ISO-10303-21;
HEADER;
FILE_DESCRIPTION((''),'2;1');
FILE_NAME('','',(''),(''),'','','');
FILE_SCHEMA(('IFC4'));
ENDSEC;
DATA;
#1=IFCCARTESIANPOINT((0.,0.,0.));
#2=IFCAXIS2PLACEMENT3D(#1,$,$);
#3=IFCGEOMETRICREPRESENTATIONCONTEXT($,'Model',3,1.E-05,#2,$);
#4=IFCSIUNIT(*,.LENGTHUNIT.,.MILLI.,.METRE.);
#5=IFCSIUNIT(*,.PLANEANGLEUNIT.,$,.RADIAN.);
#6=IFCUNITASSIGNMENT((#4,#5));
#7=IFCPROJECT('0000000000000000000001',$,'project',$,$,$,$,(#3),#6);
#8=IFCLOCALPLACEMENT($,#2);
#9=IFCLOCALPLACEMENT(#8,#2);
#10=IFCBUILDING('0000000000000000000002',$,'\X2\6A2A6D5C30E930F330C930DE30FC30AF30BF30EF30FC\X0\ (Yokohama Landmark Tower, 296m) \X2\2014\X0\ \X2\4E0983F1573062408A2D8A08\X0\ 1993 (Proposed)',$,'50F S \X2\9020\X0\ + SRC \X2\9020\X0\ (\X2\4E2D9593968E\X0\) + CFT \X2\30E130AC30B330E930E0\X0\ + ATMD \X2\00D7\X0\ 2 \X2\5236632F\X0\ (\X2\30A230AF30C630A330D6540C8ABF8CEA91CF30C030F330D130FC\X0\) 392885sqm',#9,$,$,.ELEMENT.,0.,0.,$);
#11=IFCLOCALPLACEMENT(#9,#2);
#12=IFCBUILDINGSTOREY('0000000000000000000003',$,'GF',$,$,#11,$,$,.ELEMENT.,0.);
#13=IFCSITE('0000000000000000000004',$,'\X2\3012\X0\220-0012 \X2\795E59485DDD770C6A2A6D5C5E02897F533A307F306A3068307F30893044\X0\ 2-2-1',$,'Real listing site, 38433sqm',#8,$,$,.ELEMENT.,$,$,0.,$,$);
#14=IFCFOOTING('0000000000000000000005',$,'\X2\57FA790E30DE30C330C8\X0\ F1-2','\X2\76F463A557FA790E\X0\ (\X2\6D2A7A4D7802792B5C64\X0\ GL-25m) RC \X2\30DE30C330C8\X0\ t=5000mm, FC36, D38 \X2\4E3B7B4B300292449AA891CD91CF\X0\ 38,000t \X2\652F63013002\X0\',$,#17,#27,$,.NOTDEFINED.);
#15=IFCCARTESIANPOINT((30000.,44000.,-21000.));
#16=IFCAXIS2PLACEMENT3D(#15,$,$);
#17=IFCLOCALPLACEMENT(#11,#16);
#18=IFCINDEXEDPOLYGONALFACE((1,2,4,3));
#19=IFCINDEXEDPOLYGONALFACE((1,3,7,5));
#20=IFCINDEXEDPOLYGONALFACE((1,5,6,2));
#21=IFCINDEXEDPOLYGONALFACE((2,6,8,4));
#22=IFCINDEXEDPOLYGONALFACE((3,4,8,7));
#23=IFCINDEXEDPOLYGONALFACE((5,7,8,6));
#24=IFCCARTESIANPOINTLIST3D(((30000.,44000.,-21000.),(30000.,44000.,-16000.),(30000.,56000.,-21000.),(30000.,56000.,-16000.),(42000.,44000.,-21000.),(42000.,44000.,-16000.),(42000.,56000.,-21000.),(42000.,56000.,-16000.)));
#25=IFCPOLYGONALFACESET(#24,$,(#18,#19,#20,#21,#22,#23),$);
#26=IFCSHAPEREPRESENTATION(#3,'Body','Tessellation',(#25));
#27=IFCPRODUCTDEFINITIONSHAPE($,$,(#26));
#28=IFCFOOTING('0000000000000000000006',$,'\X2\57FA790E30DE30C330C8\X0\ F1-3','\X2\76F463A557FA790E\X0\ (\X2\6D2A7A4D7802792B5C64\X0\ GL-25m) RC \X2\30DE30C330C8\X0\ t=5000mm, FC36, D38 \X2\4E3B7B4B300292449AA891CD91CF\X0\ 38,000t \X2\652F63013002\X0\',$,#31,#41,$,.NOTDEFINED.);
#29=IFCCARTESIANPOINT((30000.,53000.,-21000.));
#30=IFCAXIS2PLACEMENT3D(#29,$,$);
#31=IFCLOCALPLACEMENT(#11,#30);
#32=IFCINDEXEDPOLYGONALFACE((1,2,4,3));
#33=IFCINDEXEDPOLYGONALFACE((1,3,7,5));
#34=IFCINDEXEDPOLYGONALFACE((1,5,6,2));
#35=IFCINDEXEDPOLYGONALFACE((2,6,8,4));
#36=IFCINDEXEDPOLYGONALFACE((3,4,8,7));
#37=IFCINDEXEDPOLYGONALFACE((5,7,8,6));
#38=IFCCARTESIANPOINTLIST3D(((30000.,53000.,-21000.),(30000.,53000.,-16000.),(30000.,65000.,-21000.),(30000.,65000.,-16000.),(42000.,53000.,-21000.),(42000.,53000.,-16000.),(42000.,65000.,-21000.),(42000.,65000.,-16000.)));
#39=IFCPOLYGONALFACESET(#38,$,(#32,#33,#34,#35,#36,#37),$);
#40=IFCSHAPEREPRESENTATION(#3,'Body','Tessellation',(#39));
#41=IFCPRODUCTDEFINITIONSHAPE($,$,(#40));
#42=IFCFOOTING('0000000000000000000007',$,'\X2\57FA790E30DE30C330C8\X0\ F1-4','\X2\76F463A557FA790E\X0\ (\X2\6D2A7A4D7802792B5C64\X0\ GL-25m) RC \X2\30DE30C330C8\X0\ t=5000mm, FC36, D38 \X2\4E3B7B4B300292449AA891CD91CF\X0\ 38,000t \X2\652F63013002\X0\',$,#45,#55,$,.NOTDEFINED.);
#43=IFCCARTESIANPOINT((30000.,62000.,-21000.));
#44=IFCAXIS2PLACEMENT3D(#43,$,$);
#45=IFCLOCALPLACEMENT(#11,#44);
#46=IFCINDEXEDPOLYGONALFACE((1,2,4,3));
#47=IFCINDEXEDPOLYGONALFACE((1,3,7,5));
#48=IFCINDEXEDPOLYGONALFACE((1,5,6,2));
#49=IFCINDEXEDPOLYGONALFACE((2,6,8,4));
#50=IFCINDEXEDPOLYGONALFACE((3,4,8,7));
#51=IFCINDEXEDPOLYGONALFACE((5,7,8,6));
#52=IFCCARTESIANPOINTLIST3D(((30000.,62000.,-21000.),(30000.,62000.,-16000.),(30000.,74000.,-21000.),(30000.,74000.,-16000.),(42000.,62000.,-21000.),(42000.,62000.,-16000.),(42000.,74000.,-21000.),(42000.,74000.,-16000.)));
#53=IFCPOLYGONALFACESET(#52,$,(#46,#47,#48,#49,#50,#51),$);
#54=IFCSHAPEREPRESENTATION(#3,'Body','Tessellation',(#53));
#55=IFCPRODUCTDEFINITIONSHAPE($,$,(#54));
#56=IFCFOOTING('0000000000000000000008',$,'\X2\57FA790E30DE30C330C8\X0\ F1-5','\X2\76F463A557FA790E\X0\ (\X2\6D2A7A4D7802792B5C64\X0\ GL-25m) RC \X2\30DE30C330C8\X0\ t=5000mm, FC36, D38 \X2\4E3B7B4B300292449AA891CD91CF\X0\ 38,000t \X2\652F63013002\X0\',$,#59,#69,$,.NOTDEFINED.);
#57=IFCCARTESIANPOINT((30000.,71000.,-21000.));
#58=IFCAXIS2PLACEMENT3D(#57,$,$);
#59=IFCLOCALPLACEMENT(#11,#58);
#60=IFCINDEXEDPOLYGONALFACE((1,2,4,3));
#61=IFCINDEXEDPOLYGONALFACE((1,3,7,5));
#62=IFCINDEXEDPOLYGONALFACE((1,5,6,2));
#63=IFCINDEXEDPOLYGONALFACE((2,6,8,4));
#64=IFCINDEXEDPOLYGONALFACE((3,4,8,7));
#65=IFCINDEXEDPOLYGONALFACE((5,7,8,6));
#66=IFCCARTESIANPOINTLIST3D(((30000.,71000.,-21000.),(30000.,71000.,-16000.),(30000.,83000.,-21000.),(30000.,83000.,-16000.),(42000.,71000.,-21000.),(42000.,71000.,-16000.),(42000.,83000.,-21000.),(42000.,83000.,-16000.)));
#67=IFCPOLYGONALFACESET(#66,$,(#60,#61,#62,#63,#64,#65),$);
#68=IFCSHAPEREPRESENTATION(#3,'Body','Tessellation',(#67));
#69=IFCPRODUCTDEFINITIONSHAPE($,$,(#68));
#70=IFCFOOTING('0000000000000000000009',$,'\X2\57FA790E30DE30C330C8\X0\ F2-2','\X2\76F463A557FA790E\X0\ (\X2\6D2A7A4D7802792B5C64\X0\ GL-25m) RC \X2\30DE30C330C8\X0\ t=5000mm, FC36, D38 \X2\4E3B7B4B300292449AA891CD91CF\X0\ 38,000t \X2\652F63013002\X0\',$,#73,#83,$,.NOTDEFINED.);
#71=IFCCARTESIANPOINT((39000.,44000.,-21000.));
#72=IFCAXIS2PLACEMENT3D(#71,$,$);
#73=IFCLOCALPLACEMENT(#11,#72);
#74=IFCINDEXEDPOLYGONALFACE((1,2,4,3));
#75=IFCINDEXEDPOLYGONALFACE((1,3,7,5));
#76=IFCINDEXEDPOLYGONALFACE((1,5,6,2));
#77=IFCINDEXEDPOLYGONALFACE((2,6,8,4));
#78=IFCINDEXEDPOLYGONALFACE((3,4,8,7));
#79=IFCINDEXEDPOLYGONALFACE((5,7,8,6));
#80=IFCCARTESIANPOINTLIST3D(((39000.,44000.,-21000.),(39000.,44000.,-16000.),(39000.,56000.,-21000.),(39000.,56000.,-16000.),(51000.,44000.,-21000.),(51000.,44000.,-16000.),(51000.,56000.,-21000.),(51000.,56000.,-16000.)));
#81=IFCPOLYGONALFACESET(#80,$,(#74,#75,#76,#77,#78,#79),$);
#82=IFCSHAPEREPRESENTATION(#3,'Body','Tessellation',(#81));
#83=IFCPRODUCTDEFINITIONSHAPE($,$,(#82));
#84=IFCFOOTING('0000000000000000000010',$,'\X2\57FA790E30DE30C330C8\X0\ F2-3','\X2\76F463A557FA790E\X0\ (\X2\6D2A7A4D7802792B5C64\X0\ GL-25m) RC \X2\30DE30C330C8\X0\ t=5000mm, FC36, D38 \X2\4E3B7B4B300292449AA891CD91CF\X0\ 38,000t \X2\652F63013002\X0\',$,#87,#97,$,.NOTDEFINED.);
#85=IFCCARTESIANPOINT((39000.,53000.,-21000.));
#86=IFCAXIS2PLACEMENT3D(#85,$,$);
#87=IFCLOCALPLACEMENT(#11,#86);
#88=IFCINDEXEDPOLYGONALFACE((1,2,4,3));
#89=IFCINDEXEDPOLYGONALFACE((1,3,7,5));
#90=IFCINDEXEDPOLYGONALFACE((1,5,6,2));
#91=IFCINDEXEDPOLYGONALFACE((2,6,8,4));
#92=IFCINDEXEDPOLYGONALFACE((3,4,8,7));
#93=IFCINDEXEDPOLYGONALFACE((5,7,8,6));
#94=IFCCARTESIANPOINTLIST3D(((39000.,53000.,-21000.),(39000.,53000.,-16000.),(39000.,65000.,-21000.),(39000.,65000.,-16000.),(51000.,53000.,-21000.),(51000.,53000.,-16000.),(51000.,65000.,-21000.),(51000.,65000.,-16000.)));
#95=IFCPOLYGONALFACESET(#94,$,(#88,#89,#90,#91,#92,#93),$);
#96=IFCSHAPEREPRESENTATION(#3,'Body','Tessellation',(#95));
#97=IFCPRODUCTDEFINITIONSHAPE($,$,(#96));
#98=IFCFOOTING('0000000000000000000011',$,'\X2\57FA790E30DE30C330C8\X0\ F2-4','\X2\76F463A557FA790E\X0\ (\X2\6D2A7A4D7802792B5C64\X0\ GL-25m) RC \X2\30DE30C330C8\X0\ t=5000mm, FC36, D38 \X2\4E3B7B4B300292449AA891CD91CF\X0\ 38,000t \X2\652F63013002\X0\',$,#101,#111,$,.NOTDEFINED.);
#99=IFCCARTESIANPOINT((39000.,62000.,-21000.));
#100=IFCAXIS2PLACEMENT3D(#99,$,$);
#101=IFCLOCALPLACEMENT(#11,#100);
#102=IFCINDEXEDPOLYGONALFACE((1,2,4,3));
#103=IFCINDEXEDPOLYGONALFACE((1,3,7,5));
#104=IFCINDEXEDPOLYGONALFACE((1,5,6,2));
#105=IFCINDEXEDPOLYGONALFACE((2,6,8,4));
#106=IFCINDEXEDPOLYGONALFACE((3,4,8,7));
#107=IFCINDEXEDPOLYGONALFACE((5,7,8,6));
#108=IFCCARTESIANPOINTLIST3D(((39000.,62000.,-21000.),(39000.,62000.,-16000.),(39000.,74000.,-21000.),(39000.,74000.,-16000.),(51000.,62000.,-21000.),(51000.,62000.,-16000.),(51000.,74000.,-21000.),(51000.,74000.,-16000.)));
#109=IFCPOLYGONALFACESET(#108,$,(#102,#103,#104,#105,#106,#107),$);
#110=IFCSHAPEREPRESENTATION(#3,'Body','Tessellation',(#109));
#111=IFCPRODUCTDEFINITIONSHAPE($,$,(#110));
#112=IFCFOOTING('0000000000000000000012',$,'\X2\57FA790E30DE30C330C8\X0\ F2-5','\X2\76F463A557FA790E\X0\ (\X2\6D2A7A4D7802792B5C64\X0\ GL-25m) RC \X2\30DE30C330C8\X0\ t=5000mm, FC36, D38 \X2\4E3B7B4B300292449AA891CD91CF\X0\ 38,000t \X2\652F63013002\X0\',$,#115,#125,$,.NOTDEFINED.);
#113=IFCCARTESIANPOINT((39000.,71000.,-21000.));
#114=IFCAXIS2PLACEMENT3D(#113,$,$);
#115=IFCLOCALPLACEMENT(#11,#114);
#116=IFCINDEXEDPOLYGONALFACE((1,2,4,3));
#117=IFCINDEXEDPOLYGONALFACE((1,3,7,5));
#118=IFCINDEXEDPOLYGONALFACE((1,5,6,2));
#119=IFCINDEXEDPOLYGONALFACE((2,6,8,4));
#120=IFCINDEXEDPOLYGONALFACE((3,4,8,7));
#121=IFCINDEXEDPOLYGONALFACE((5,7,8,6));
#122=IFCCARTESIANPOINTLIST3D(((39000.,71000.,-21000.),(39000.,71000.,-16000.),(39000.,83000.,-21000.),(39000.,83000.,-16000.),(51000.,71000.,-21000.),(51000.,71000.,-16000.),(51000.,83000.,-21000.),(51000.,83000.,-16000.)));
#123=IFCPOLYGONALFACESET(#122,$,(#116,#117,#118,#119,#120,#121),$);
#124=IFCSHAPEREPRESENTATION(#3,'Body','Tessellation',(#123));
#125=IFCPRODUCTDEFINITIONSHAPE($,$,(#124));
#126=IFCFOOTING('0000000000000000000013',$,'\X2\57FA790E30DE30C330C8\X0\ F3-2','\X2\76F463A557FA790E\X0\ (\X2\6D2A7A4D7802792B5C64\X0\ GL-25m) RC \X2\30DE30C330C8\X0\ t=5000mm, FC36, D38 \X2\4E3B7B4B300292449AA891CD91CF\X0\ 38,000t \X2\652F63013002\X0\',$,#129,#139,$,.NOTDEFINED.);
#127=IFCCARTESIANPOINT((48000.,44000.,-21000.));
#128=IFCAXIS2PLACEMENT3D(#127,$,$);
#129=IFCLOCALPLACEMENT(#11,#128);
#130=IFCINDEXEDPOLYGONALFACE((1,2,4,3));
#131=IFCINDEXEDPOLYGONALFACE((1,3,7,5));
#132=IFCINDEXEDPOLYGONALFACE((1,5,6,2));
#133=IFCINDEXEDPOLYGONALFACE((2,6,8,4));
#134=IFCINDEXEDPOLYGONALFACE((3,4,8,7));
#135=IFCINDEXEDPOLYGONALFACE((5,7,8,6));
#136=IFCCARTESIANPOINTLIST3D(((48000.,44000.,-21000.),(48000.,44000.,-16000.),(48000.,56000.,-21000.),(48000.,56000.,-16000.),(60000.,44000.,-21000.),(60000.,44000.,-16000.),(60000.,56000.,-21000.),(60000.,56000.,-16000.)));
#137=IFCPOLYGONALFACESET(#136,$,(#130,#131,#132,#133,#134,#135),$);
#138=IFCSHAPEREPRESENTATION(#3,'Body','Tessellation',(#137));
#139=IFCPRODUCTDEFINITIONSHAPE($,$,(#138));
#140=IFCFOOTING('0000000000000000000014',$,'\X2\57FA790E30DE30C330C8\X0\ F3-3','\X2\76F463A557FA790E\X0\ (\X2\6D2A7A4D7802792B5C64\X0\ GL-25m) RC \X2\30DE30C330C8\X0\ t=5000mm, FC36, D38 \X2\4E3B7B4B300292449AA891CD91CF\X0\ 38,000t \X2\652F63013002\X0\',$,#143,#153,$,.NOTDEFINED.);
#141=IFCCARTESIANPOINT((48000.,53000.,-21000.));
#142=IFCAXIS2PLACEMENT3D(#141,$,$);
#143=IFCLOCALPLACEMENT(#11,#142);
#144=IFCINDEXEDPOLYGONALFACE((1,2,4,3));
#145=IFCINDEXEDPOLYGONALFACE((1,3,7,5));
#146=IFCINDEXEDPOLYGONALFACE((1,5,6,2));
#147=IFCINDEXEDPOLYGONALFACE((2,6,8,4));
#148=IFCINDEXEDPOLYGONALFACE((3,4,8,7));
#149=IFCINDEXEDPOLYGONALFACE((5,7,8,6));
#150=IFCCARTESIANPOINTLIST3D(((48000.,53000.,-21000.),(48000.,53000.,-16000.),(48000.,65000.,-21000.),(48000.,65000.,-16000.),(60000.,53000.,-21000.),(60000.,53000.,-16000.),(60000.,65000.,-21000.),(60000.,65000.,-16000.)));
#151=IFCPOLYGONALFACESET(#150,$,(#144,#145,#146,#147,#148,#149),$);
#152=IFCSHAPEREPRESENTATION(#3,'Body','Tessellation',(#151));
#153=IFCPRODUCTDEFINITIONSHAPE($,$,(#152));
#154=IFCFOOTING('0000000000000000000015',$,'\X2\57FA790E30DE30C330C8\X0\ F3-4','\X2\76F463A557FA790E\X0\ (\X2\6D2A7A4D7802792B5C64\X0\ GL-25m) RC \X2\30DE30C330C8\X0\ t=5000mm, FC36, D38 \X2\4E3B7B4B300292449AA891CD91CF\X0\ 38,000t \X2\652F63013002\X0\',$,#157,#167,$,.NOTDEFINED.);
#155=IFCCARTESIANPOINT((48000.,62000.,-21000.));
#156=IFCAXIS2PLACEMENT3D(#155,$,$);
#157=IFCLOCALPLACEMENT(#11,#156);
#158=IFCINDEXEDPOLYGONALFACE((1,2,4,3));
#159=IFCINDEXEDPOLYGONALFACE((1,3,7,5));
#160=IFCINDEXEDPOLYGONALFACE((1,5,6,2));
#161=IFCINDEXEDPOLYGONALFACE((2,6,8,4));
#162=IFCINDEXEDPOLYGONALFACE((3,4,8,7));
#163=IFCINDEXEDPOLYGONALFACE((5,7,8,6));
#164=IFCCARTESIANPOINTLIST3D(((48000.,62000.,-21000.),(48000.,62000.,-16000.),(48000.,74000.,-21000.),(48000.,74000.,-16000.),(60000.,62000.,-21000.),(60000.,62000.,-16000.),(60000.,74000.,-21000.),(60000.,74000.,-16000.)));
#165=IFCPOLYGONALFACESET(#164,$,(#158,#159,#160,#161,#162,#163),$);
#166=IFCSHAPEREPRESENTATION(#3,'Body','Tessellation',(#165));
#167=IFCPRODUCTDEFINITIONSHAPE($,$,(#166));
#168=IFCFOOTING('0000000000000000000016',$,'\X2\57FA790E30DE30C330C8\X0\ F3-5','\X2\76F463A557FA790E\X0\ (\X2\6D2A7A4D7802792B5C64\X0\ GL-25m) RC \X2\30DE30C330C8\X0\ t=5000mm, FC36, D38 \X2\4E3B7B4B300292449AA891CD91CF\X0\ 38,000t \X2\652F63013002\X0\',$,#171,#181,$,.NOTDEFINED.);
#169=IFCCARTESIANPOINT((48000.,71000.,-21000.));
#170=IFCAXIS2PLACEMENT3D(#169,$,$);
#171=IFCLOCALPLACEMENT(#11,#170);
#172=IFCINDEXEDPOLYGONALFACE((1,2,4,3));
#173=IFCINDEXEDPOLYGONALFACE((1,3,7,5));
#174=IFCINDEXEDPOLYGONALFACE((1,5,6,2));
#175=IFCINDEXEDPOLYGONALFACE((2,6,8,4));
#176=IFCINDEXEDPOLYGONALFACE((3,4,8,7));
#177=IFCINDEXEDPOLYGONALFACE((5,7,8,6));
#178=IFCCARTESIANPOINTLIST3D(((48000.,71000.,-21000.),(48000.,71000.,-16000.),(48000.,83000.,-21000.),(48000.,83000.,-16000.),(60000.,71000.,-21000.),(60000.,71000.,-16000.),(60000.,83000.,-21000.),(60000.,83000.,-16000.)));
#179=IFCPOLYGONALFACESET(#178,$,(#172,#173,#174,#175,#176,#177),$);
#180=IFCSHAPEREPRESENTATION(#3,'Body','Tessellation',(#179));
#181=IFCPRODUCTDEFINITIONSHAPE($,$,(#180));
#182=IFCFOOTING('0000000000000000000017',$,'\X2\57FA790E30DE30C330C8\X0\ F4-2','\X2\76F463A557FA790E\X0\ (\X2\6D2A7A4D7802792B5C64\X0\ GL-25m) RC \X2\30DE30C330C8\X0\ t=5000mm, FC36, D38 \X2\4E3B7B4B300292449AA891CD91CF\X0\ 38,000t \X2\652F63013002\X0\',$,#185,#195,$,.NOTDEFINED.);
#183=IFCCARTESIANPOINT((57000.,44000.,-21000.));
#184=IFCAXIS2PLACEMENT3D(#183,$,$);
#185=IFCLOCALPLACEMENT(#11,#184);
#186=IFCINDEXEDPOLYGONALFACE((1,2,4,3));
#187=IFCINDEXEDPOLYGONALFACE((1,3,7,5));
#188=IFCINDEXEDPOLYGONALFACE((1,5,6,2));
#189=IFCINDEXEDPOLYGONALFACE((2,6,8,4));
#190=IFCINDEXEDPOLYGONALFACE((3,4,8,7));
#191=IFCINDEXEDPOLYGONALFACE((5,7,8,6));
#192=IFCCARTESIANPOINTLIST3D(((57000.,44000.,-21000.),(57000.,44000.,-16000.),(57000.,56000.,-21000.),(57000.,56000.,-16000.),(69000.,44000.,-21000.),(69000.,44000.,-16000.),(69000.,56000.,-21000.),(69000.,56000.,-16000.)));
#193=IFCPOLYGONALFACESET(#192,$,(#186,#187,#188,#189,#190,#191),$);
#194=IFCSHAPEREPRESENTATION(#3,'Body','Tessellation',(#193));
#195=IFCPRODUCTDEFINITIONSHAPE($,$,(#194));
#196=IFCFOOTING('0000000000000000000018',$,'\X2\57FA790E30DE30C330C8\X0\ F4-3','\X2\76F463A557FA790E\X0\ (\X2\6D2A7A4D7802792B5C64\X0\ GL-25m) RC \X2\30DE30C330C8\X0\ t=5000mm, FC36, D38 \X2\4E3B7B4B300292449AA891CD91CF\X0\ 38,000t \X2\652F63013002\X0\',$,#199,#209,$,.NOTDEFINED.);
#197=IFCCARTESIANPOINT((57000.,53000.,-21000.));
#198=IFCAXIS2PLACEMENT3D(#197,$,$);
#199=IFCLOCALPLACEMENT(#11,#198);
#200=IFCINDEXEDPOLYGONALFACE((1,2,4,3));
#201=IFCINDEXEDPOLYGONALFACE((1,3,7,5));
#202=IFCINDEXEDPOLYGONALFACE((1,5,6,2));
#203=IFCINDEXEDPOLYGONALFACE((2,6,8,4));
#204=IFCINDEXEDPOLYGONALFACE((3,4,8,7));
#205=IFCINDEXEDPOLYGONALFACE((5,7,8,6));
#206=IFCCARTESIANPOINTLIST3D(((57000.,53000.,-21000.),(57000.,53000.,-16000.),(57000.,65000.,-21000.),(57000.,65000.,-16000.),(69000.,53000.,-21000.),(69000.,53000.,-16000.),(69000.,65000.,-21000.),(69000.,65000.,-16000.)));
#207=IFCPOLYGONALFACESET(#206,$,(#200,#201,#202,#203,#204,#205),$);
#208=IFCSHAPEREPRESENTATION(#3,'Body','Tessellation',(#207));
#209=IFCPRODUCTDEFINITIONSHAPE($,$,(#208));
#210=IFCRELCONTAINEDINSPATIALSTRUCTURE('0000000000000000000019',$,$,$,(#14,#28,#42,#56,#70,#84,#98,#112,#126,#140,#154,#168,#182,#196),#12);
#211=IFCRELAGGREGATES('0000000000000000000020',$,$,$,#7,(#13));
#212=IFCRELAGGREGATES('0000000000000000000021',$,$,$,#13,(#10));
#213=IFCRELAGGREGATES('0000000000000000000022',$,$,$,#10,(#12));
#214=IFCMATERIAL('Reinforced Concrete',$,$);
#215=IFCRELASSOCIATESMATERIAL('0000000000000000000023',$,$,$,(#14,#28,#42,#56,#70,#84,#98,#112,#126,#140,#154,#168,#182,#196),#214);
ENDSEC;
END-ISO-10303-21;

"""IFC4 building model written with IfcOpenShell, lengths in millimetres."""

from ifc_helpers import new_model, si_unit, frame, frame_2d, origin, place, context, project, spatial, rectangle, extrude, material, element, save


model = new_model("IFC4")

# Units and contexts
model_context = context("Model", 3, precision=1e-05, world=origin())
ifc_project = project(units=[si_unit("LENGTHUNIT", "METRE", prefix="MILLI"), si_unit("PLANEANGLEUNIT", "RADIAN")], contexts=[model_context])

# Site, building, storey
site_placement = place(None, origin())
site = spatial("IfcSite", under=ifc_project, at=site_placement, Name="〒220-0012 神奈川県横浜市西区みなとみらい 2-2-1", ObjectType="Real listing site, 38433sqm", CompositionType="ELEMENT", RefElevation=0.0)
building_placement = place(site_placement, origin())
building = spatial("IfcBuilding", under=site, at=building_placement, Name="横浜ランドマークタワー (Yokohama Landmark Tower, 296m) — 三菱地所設計 1993 (Proposed)", ObjectType="50F S 造 + SRC 造 (中間階) + CFT メガコラム + ATMD × 2 制振 (アクティブ同調質量ダンパー) 392885sqm", CompositionType="ELEMENT", ElevationOfRefHeight=0.0, ElevationOfTerrain=0.0)
storey_placement = place(building_placement, origin())
storey = spatial("IfcBuildingStorey", under=building, at=storey_placement, Name="GF", CompositionType="ELEMENT", Elevation=0.0)

# Footings
ifc_material_1 = material(Name="Reinforced Concrete")
footing_1_placement = place(storey_placement, frame((30000.0, 44000.0, -21000.0)))
element("IfcFooting", 1, at=footing_1_placement, inside=storey, material=ifc_material_1, Name="基礎マット F1-2", Description="直接基礎 (洪積砂礫層 GL-25m) RC マット t=5000mm, FC36, D38 主筋。鉄骨重量 38,000t 支持。", PredefinedType="NOTDEFINED", context=model_context, shape_type="SweptSolid", body=[
    extrude(rectangle(XDim=12000.0, YDim=12000.0, at=frame_2d((6000.0, 6000.0))), frame((30000.0, 44000.0, -21000.0)), (0.0, 0.0, 1.0), 5000.0),
])
footing_2_placement = place(storey_placement, frame((30000.0, 53000.0, -21000.0)))
element("IfcFooting", 2, at=footing_2_placement, inside=storey, material=ifc_material_1, Name="基礎マット F1-3", Description="直接基礎 (洪積砂礫層 GL-25m) RC マット t=5000mm, FC36, D38 主筋。鉄骨重量 38,000t 支持。", PredefinedType="NOTDEFINED", context=model_context, shape_type="SweptSolid", body=[
    extrude(rectangle(XDim=12000.0, YDim=12000.0, at=frame_2d((6000.0, 6000.0))), frame((30000.0, 53000.0, -21000.0)), (0.0, 0.0, 1.0), 5000.0),
])
footing_3_placement = place(storey_placement, frame((30000.0, 62000.0, -21000.0)))
element("IfcFooting", 3, at=footing_3_placement, inside=storey, material=ifc_material_1, Name="基礎マット F1-4", Description="直接基礎 (洪積砂礫層 GL-25m) RC マット t=5000mm, FC36, D38 主筋。鉄骨重量 38,000t 支持。", PredefinedType="NOTDEFINED", context=model_context, shape_type="SweptSolid", body=[
    extrude(rectangle(XDim=12000.0, YDim=12000.0, at=frame_2d((6000.0, 6000.0))), frame((30000.0, 62000.0, -21000.0)), (0.0, 0.0, 1.0), 5000.0),
])
footing_4_placement = place(storey_placement, frame((30000.0, 71000.0, -21000.0)))
element("IfcFooting", 4, at=footing_4_placement, inside=storey, material=ifc_material_1, Name="基礎マット F1-5", Description="直接基礎 (洪積砂礫層 GL-25m) RC マット t=5000mm, FC36, D38 主筋。鉄骨重量 38,000t 支持。", PredefinedType="NOTDEFINED", context=model_context, shape_type="SweptSolid", body=[
    extrude(rectangle(XDim=12000.0, YDim=12000.0, at=frame_2d((6000.0, 6000.0))), frame((30000.0, 71000.0, -21000.0)), (0.0, 0.0, 1.0), 5000.0),
])
footing_5_placement = place(storey_placement, frame((39000.0, 44000.0, -21000.0)))
element("IfcFooting", 5, at=footing_5_placement, inside=storey, material=ifc_material_1, Name="基礎マット F2-2", Description="直接基礎 (洪積砂礫層 GL-25m) RC マット t=5000mm, FC36, D38 主筋。鉄骨重量 38,000t 支持。", PredefinedType="NOTDEFINED", context=model_context, shape_type="SweptSolid", body=[
    extrude(rectangle(XDim=12000.0, YDim=12000.0, at=frame_2d((6000.0, 6000.0))), frame((39000.0, 44000.0, -21000.0)), (0.0, 0.0, 1.0), 5000.0),
])
footing_6_placement = place(storey_placement, frame((39000.0, 53000.0, -21000.0)))
element("IfcFooting", 6, at=footing_6_placement, inside=storey, material=ifc_material_1, Name="基礎マット F2-3", Description="直接基礎 (洪積砂礫層 GL-25m) RC マット t=5000mm, FC36, D38 主筋。鉄骨重量 38,000t 支持。", PredefinedType="NOTDEFINED", context=model_context, shape_type="SweptSolid", body=[
    extrude(rectangle(XDim=12000.0, YDim=12000.0, at=frame_2d((6000.0, 6000.0))), frame((39000.0, 53000.0, -21000.0)), (0.0, 0.0, 1.0), 5000.0),
])
footing_7_placement = place(storey_placement, frame((39000.0, 62000.0, -21000.0)))
element("IfcFooting", 7, at=footing_7_placement, inside=storey, material=ifc_material_1, Name="基礎マット F2-4", Description="直接基礎 (洪積砂礫層 GL-25m) RC マット t=5000mm, FC36, D38 主筋。鉄骨重量 38,000t 支持。", PredefinedType="NOTDEFINED", context=model_context, shape_type="SweptSolid", body=[
    extrude(rectangle(XDim=12000.0, YDim=12000.0, at=frame_2d((6000.0, 6000.0))), frame((39000.0, 62000.0, -21000.0)), (0.0, 0.0, 1.0), 5000.0),
])
footing_8_placement = place(storey_placement, frame((39000.0, 71000.0, -21000.0)))
element("IfcFooting", 8, at=footing_8_placement, inside=storey, material=ifc_material_1, Name="基礎マット F2-5", Description="直接基礎 (洪積砂礫層 GL-25m) RC マット t=5000mm, FC36, D38 主筋。鉄骨重量 38,000t 支持。", PredefinedType="NOTDEFINED", context=model_context, shape_type="SweptSolid", body=[
    extrude(rectangle(XDim=12000.0, YDim=12000.0, at=frame_2d((6000.0, 6000.0))), frame((39000.0, 71000.0, -21000.0)), (0.0, 0.0, 1.0), 5000.0),
])
footing_9_placement = place(storey_placement, frame((48000.0, 44000.0, -21000.0)))
element("IfcFooting", 9, at=footing_9_placement, inside=storey, material=ifc_material_1, Name="基礎マット F3-2", Description="直接基礎 (洪積砂礫層 GL-25m) RC マット t=5000mm, FC36, D38 主筋。鉄骨重量 38,000t 支持。", PredefinedType="NOTDEFINED", context=model_context, shape_type="SweptSolid", body=[
    extrude(rectangle(XDim=12000.0, YDim=12000.0, at=frame_2d((6000.0, 6000.0))), frame((48000.0, 44000.0, -21000.0)), (0.0, 0.0, 1.0), 5000.0),
])
footing_10_placement = place(storey_placement, frame((48000.0, 53000.0, -21000.0)))
element("IfcFooting", 10, at=footing_10_placement, inside=storey, material=ifc_material_1, Name="基礎マット F3-3", Description="直接基礎 (洪積砂礫層 GL-25m) RC マット t=5000mm, FC36, D38 主筋。鉄骨重量 38,000t 支持。", PredefinedType="NOTDEFINED", context=model_context, shape_type="SweptSolid", body=[
    extrude(rectangle(XDim=12000.0, YDim=12000.0, at=frame_2d((6000.0, 6000.0))), frame((48000.0, 53000.0, -21000.0)), (0.0, 0.0, 1.0), 5000.0),
])
footing_11_placement = place(storey_placement, frame((48000.0, 62000.0, -21000.0)))
element("IfcFooting", 11, at=footing_11_placement, inside=storey, material=ifc_material_1, Name="基礎マット F3-4", Description="直接基礎 (洪積砂礫層 GL-25m) RC マット t=5000mm, FC36, D38 主筋。鉄骨重量 38,000t 支持。", PredefinedType="NOTDEFINED", context=model_context, shape_type="SweptSolid", body=[
    extrude(rectangle(XDim=12000.0, YDim=12000.0, at=frame_2d((6000.0, 6000.0))), frame((48000.0, 62000.0, -21000.0)), (0.0, 0.0, 1.0), 5000.0),
])
footing_12_placement = place(storey_placement, frame((48000.0, 71000.0, -21000.0)))
element("IfcFooting", 12, at=footing_12_placement, inside=storey, material=ifc_material_1, Name="基礎マット F3-5", Description="直接基礎 (洪積砂礫層 GL-25m) RC マット t=5000mm, FC36, D38 主筋。鉄骨重量 38,000t 支持。", PredefinedType="NOTDEFINED", context=model_context, shape_type="SweptSolid", body=[
    extrude(rectangle(XDim=12000.0, YDim=12000.0, at=frame_2d((6000.0, 6000.0))), frame((48000.0, 71000.0, -21000.0)), (0.0, 0.0, 1.0), 5000.0),
])
footing_13_placement = place(storey_placement, frame((57000.0, 44000.0, -21000.0)))
element("IfcFooting", 13, at=footing_13_placement, inside=storey, material=ifc_material_1, Name="基礎マット F4-2", Description="直接基礎 (洪積砂礫層 GL-25m) RC マット t=5000mm, FC36, D38 主筋。鉄骨重量 38,000t 支持。", PredefinedType="NOTDEFINED", context=model_context, shape_type="SweptSolid", body=[
    extrude(rectangle(XDim=12000.0, YDim=12000.0, at=frame_2d((6000.0, 6000.0))), frame((57000.0, 44000.0, -21000.0)), (0.0, 0.0, 1.0), 5000.0),
])
footing_14_placement = place(storey_placement, frame((57000.0, 53000.0, -21000.0)))
element("IfcFooting", 14, at=footing_14_placement, inside=storey, material=ifc_material_1, Name="基礎マット F4-3", Description="直接基礎 (洪積砂礫層 GL-25m) RC マット t=5000mm, FC36, D38 主筋。鉄骨重量 38,000t 支持。", PredefinedType="NOTDEFINED", context=model_context, shape_type="SweptSolid", body=[
    extrude(rectangle(XDim=12000.0, YDim=12000.0, at=frame_2d((6000.0, 6000.0))), frame((57000.0, 53000.0, -21000.0)), (0.0, 0.0, 1.0), 5000.0),
])

save(model, "model.ifc")
